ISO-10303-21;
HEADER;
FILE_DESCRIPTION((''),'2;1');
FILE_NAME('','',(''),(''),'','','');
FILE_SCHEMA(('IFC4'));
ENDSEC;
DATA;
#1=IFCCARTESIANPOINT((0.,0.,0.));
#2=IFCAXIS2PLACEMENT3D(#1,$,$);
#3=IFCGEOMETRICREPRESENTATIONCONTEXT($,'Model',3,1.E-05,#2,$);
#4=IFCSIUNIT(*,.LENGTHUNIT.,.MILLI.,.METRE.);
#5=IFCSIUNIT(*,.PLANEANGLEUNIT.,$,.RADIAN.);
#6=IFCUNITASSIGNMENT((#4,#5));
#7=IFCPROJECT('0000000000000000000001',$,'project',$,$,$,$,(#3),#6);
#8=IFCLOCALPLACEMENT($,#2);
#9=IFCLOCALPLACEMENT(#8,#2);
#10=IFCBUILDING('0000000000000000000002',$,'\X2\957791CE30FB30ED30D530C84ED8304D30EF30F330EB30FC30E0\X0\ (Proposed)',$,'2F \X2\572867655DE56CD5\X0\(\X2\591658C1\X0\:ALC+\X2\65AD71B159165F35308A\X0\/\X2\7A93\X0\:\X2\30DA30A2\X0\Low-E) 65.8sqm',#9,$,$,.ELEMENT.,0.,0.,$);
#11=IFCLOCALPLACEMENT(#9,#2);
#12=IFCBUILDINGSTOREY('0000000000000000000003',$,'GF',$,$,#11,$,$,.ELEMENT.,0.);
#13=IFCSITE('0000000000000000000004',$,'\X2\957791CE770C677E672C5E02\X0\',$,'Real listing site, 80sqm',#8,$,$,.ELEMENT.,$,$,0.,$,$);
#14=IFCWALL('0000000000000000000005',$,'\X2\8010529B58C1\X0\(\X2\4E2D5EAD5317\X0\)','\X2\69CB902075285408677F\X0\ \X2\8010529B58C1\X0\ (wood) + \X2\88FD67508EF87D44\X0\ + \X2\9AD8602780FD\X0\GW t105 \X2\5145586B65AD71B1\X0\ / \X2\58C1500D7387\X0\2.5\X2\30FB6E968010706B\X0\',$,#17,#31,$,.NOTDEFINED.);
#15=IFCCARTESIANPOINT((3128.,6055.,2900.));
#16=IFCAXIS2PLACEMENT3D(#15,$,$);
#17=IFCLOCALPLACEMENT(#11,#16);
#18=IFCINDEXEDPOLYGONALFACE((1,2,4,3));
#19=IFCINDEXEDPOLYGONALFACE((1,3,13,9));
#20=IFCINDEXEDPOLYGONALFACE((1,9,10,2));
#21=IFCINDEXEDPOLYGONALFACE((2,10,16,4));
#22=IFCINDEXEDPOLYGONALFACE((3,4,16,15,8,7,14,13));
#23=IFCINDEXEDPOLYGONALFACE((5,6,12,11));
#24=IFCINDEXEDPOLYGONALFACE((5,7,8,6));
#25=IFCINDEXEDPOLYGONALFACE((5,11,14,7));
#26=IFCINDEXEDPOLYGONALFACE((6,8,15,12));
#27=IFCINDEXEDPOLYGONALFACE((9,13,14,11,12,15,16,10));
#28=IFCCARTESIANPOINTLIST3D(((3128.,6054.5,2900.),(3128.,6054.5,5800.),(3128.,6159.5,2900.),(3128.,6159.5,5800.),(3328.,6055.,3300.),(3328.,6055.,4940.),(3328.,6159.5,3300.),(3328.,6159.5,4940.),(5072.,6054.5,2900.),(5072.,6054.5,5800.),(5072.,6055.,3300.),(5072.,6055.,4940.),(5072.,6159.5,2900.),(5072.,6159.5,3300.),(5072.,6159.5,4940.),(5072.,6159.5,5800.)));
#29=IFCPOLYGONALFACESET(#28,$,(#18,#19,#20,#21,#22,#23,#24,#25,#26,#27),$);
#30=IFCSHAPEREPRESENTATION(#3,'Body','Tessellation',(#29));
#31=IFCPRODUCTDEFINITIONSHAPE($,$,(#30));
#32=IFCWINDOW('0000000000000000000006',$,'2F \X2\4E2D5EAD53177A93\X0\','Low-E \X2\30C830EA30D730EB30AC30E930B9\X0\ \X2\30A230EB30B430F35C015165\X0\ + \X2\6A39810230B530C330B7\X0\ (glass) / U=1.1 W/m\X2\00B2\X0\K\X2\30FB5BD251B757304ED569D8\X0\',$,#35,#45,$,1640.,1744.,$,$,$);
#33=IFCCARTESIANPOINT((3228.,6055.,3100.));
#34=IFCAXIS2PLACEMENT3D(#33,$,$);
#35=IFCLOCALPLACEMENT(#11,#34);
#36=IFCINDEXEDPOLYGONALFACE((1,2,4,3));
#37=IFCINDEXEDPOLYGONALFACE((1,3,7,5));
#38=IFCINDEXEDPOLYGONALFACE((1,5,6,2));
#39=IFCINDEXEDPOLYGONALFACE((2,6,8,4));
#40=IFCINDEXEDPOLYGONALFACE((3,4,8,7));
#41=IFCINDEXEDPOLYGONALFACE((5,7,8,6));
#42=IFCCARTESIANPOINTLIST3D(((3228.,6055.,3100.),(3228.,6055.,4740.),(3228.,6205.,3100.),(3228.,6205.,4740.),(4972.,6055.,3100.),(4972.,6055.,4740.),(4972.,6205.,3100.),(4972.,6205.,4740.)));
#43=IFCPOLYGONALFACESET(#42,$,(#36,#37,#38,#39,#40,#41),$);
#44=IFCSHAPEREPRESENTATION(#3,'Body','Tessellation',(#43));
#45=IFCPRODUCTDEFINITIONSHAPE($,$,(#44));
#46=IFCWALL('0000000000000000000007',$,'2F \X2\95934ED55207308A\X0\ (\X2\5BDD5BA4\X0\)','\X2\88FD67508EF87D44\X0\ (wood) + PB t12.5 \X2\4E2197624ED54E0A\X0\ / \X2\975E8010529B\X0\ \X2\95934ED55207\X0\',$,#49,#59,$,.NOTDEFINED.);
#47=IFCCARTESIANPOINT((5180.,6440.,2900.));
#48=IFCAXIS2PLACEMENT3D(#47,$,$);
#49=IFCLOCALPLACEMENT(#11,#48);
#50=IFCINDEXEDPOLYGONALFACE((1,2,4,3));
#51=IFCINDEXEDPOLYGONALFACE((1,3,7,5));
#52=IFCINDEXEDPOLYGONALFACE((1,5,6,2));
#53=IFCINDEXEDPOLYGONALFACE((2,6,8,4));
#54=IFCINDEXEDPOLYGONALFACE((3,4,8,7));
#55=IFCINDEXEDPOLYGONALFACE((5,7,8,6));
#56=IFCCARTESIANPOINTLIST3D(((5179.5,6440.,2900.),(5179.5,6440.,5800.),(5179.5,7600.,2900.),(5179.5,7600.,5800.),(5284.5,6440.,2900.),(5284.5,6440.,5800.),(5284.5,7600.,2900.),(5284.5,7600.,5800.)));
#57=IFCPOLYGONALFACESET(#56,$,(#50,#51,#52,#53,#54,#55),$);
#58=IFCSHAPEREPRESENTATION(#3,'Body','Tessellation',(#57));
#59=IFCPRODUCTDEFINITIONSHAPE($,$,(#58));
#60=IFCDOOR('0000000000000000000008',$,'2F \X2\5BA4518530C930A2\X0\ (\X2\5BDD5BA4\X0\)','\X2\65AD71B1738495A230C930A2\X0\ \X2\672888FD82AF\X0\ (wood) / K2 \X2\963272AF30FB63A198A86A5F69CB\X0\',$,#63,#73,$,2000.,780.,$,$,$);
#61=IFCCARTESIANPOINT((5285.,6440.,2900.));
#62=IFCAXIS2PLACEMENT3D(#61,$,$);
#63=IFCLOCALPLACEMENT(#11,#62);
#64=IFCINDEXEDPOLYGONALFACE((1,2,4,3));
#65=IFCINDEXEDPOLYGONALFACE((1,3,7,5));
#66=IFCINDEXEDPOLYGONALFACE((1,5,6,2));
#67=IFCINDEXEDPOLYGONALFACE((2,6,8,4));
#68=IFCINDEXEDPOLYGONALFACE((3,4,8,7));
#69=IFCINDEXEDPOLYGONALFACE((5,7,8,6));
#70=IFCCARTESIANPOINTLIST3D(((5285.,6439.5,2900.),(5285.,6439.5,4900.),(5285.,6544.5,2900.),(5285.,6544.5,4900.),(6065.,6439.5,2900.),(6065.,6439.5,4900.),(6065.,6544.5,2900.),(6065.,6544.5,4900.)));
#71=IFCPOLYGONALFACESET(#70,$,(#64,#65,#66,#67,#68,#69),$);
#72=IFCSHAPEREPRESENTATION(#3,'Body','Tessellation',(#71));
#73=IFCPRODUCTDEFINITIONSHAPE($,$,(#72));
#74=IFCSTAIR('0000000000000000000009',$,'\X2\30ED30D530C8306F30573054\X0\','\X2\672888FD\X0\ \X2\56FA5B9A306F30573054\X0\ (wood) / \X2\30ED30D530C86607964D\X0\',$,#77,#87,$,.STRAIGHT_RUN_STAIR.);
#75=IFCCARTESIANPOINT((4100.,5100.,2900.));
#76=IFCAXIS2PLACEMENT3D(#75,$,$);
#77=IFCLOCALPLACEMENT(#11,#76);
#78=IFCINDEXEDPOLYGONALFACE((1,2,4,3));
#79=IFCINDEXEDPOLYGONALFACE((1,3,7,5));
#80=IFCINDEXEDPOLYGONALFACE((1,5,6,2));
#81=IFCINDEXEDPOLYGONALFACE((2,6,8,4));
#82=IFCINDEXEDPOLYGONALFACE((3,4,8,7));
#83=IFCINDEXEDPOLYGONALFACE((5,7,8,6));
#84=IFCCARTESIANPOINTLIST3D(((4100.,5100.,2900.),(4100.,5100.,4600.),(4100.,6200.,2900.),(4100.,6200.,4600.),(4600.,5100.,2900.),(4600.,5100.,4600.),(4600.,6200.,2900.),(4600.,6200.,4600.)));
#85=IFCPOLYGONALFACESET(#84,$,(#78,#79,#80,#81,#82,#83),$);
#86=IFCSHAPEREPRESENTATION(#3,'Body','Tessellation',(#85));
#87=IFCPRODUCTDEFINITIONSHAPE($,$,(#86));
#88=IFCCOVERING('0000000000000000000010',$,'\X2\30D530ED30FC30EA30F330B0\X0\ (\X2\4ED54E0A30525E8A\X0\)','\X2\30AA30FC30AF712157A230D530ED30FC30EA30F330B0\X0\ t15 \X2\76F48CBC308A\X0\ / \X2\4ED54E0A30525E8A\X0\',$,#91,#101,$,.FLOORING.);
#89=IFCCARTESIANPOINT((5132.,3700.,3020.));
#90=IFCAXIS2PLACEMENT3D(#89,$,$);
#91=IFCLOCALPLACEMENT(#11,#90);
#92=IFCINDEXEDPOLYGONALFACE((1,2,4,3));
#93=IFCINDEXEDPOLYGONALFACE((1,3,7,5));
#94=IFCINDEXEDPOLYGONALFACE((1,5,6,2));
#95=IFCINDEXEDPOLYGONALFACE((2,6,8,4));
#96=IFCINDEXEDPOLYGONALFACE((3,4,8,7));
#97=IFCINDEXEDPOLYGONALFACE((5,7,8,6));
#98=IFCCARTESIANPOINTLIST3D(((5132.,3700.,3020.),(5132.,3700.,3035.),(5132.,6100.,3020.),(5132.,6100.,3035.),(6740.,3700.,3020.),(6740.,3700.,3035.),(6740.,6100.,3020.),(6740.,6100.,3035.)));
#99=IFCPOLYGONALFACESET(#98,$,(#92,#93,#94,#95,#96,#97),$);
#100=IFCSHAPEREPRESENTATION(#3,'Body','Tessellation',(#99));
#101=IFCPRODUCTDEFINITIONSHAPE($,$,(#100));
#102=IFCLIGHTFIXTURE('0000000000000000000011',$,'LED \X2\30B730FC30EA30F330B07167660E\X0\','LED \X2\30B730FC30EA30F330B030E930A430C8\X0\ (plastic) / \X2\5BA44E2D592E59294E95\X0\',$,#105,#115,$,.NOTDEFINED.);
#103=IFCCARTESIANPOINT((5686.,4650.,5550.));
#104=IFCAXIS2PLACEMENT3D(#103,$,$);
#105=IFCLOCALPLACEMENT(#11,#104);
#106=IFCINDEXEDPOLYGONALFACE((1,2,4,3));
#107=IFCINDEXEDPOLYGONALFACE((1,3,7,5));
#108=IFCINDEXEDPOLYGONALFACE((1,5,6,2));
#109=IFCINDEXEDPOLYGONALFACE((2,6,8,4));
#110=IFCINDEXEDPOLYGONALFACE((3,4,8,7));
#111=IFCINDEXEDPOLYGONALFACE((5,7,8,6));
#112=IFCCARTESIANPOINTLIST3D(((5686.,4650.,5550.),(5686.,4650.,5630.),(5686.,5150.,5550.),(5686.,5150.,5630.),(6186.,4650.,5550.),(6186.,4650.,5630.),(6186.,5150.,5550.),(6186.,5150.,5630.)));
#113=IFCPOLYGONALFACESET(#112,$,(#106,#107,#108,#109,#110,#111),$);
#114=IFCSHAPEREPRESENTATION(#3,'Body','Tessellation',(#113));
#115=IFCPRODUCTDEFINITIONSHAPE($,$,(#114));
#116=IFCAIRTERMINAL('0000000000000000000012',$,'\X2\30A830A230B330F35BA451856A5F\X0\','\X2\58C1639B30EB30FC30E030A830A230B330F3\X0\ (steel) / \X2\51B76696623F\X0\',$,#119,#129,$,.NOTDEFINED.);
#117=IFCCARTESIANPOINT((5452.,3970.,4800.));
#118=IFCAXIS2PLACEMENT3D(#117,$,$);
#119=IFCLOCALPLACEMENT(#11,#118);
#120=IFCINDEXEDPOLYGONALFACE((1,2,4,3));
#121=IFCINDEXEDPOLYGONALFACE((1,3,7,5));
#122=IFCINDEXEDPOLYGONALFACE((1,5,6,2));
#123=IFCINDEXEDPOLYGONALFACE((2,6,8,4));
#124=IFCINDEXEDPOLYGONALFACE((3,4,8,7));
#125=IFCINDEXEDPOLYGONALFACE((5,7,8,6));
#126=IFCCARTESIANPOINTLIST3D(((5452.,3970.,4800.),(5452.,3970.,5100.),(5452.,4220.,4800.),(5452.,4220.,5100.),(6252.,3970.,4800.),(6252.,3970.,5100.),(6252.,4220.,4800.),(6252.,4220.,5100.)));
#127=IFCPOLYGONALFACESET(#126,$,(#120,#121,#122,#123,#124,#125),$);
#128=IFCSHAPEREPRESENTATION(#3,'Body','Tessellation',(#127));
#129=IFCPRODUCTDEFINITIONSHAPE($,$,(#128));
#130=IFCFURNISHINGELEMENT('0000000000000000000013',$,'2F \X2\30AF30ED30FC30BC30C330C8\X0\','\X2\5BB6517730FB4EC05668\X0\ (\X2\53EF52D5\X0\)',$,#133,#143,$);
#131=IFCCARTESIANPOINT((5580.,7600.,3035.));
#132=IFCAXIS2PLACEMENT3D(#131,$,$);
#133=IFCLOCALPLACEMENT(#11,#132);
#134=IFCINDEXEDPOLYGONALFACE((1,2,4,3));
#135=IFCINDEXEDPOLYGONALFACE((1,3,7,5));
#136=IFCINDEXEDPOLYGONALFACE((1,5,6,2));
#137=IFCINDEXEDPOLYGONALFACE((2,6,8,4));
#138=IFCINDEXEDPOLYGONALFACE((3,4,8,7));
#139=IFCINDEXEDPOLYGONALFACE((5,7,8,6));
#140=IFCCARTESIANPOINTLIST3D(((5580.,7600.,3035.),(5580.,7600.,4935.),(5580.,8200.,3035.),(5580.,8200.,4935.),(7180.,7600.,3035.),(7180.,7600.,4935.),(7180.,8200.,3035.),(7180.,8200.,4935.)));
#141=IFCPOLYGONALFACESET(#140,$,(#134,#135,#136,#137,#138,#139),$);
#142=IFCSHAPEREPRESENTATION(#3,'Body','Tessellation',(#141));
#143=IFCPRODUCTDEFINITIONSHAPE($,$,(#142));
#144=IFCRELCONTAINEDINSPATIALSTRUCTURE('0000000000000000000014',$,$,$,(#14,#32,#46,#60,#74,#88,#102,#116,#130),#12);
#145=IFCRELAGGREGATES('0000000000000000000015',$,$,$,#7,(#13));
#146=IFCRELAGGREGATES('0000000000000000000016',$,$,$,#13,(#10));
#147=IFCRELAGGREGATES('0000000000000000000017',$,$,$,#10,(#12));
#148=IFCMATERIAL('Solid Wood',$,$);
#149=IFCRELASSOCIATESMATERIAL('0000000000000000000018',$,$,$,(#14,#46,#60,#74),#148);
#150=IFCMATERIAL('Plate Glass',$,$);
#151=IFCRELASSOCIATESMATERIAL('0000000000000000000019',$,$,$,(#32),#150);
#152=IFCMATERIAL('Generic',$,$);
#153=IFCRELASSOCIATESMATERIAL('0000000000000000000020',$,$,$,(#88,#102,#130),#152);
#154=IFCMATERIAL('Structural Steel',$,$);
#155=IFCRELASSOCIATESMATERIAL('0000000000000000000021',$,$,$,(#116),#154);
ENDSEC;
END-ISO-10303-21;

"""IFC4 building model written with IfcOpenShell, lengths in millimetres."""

from ifc_helpers import new_model, si_unit, frame, frame_2d, origin, place, context, project, spatial, rectangle, extrude, material, element, fill, save


model = new_model("IFC4")

# Units and contexts
model_context = context("Model", 3, precision=1e-05, world=origin())
ifc_project = project(units=[si_unit("LENGTHUNIT", "METRE", prefix="MILLI"), si_unit("PLANEANGLEUNIT", "RADIAN")], contexts=[model_context])

# Site, building, storey
site_placement = place(None, origin())
site = spatial("IfcSite", under=ifc_project, at=site_placement, Name="長野県松本市", ObjectType="Real listing site, 80sqm", CompositionType="ELEMENT", RefElevation=0.0)
building_placement = place(site_placement, origin())
building = spatial("IfcBuilding", under=site, at=building_placement, Name="長野・ロフト付きワンルーム (Proposed)", ObjectType="2F 在来工法(外壁:ALC+断熱外張り/窓:ペアLow-E) 65.8sqm", CompositionType="ELEMENT", ElevationOfRefHeight=0.0, ElevationOfTerrain=0.0)
storey_placement = place(building_placement, origin())
storey = spatial("IfcBuildingStorey", under=building, at=storey_placement, Name="GF", CompositionType="ELEMENT", Elevation=0.0)

# Shared definitions
ifc_material_1 = material(Name="Solid Wood")

# Wall, opening, window
wall_1_placement = place(storey_placement, frame((3128.0, 6055.0, 2900.0)))
wall_1 = element("IfcWall", 1, at=wall_1_placement, inside=storey, material=ifc_material_1, Name="耐力壁(中庭北)", Description="構造用合板 耐力壁 (wood) + 製材軸組 + 高性能GW t105 充填断熱 / 壁倍率2.5・準耐火", PredefinedType="NOTDEFINED", context=model_context, shape_type="SweptSolid", body=[
    extrude(rectangle(XDim=1944.0, YDim=105.0, at=frame_2d((972.0, 52.0))), frame((3128.0, 6055.0, 2900.0)), (0.0, 0.0, 1.0), 2900.0),
])
opening_placement = place(storey_placement, frame((3228.0, 6055.0, 3100.0)))
opening = element("IfcOpeningElement", 2, at=opening_placement, cuts=wall_1, PredefinedType="NOTDEFINED", context=model_context, shape_type="SweptSolid", body=[
    extrude(rectangle(XDim=1744.0, YDim=150.0, at=frame_2d((872.0, 75.0))), frame((3228.0, 6055.0, 3100.0)), (0.0, 0.0, 1.0), 1640.0),
])
ifc_material_2 = material(Name="Plate Glass")
window_placement = place(storey_placement, frame((3228.0, 6055.0, 3100.0)))
window = element("IfcWindow", 3, at=window_placement, inside=storey, material=ifc_material_2, Name="2F 中庭北窓", Description="Low-E トリプルガラス アルゴン封入 + 樹脂サッシ (glass) / U=1.1 W/m²K・寒冷地仕様", OverallHeight=1640.0, OverallWidth=1744.0, context=model_context, shape_type="SweptSolid", body=[
    extrude(rectangle(XDim=1744.0, YDim=150.0, at=frame_2d((872.0, 75.0))), frame((3228.0, 6055.0, 3100.0)), (0.0, 0.0, 1.0), 1640.0),
])
fill(opening, window)

# Wall
wall_2_placement = place(storey_placement, frame((5180.0, 6440.0, 2900.0)))
element("IfcWall", 4, at=wall_2_placement, inside=storey, material=ifc_material_1, Name="2F 間仕切り (寝室)", Description="製材軸組 (wood) + PB t12.5 両面仕上 / 非耐力 間仕切", PredefinedType="NOTDEFINED", context=model_context, shape_type="SweptSolid", body=[
    extrude(rectangle(XDim=105.0, YDim=1160.0, at=frame_2d((52.0, 580.0))), frame((5180.0, 6440.0, 2900.0)), (0.0, 0.0, 1.0), 2900.0),
])

# Door
door_placement = place(storey_placement, frame((5285.0, 6440.0, 2900.0)))
element("IfcDoor", 5, at=door_placement, inside=storey, material=ifc_material_1, Name="2F 室内ドア (寝室)", Description="断熱玄関ドア 木製芯 (wood) / K2 防犯・採風機構", OverallHeight=2000.0, OverallWidth=780.0, context=model_context, shape_type="SweptSolid", body=[
    extrude(rectangle(XDim=780.0, YDim=105.0, at=frame_2d((390.0, 52.0))), frame((5285.0, 6440.0, 2900.0)), (0.0, 0.0, 1.0), 2000.0),
])

# Stair
stair_placement = place(storey_placement, frame((4100.0, 5100.0, 2900.0)))
element("IfcStair", 6, at=stair_placement, inside=storey, material=ifc_material_1, Name="ロフトはしご", Description="木製 固定はしご (wood) / ロフト昇降", PredefinedType="STRAIGHT_RUN_STAIR", context=model_context, shape_type="SweptSolid", body=[
    extrude(rectangle(XDim=500.0, YDim=1100.0, at=frame_2d((250.0, 550.0))), frame((4100.0, 5100.0, 2900.0)), (0.0, 0.0, 1.0), 1700.0),
])

# Covering
ifc_material_3 = material(Name="Generic")
covering_placement = place(storey_placement, frame((5132.0, 3700.0, 3020.0)))
element("IfcCovering", 7, at=covering_placement, inside=storey, material=ifc_material_3, Name="フローリング (仕上げ床)", Description="オーク無垢フローリング t15 直貼り / 仕上げ床", PredefinedType="FLOORING", context=model_context, shape_type="SweptSolid", body=[
    extrude(rectangle(XDim=1608.0, YDim=2400.0, at=frame_2d((804.0, 1200.0))), frame((5132.0, 3700.0, 3020.0)), (0.0, 0.0, 1.0), 15.0),
])

# Light fixture
light_fixture_placement = place(storey_placement, frame((5686.0, 4650.0, 5550.0)))
element("IfcLightFixture", 8, at=light_fixture_placement, inside=storey, material=ifc_material_3, Name="LED シーリング照明", Description="LED シーリングライト (plastic) / 室中央天井", PredefinedType="NOTDEFINED", context=model_context, shape_type="SweptSolid", body=[
    extrude(rectangle(XDim=500.0, YDim=500.0, at=frame_2d((250.0, 250.0))), frame((5686.0, 4650.0, 5550.0)), (0.0, 0.0, 1.0), 80.0),
])

# Air terminal
ifc_material_4 = material(Name="Structural Steel")
air_terminal_placement = place(storey_placement, frame((5452.0, 3970.0, 4800.0)))
element("IfcAirTerminal", 9, at=air_terminal_placement, inside=storey, material=ifc_material_4, Name="エアコン室内機", Description="壁掛ルームエアコン (steel) / 冷暖房", PredefinedType="NOTDEFINED", context=model_context, shape_type="SweptSolid", body=[
    extrude(rectangle(XDim=800.0, YDim=250.0, at=frame_2d((400.0, 125.0))), frame((5452.0, 3970.0, 4800.0)), (0.0, 0.0, 1.0), 300.0),
])

# Furnishing element
furnishing_placement = place(storey_placement, frame((5580.0, 7600.0, 3035.0)))
element("IfcFurnishingElement", 10, at=furnishing_placement, inside=storey, material=ifc_material_3, Name="2F クローゼット", Description="家具・什器 (可動)", context=model_context, shape_type="SweptSolid", body=[
    extrude(rectangle(XDim=1600.0, YDim=600.0, at=frame_2d((800.0, 300.0))), frame((5580.0, 7600.0, 3035.0)), (0.0, 0.0, 1.0), 1900.0),
])

save(model, "model.ifc")
